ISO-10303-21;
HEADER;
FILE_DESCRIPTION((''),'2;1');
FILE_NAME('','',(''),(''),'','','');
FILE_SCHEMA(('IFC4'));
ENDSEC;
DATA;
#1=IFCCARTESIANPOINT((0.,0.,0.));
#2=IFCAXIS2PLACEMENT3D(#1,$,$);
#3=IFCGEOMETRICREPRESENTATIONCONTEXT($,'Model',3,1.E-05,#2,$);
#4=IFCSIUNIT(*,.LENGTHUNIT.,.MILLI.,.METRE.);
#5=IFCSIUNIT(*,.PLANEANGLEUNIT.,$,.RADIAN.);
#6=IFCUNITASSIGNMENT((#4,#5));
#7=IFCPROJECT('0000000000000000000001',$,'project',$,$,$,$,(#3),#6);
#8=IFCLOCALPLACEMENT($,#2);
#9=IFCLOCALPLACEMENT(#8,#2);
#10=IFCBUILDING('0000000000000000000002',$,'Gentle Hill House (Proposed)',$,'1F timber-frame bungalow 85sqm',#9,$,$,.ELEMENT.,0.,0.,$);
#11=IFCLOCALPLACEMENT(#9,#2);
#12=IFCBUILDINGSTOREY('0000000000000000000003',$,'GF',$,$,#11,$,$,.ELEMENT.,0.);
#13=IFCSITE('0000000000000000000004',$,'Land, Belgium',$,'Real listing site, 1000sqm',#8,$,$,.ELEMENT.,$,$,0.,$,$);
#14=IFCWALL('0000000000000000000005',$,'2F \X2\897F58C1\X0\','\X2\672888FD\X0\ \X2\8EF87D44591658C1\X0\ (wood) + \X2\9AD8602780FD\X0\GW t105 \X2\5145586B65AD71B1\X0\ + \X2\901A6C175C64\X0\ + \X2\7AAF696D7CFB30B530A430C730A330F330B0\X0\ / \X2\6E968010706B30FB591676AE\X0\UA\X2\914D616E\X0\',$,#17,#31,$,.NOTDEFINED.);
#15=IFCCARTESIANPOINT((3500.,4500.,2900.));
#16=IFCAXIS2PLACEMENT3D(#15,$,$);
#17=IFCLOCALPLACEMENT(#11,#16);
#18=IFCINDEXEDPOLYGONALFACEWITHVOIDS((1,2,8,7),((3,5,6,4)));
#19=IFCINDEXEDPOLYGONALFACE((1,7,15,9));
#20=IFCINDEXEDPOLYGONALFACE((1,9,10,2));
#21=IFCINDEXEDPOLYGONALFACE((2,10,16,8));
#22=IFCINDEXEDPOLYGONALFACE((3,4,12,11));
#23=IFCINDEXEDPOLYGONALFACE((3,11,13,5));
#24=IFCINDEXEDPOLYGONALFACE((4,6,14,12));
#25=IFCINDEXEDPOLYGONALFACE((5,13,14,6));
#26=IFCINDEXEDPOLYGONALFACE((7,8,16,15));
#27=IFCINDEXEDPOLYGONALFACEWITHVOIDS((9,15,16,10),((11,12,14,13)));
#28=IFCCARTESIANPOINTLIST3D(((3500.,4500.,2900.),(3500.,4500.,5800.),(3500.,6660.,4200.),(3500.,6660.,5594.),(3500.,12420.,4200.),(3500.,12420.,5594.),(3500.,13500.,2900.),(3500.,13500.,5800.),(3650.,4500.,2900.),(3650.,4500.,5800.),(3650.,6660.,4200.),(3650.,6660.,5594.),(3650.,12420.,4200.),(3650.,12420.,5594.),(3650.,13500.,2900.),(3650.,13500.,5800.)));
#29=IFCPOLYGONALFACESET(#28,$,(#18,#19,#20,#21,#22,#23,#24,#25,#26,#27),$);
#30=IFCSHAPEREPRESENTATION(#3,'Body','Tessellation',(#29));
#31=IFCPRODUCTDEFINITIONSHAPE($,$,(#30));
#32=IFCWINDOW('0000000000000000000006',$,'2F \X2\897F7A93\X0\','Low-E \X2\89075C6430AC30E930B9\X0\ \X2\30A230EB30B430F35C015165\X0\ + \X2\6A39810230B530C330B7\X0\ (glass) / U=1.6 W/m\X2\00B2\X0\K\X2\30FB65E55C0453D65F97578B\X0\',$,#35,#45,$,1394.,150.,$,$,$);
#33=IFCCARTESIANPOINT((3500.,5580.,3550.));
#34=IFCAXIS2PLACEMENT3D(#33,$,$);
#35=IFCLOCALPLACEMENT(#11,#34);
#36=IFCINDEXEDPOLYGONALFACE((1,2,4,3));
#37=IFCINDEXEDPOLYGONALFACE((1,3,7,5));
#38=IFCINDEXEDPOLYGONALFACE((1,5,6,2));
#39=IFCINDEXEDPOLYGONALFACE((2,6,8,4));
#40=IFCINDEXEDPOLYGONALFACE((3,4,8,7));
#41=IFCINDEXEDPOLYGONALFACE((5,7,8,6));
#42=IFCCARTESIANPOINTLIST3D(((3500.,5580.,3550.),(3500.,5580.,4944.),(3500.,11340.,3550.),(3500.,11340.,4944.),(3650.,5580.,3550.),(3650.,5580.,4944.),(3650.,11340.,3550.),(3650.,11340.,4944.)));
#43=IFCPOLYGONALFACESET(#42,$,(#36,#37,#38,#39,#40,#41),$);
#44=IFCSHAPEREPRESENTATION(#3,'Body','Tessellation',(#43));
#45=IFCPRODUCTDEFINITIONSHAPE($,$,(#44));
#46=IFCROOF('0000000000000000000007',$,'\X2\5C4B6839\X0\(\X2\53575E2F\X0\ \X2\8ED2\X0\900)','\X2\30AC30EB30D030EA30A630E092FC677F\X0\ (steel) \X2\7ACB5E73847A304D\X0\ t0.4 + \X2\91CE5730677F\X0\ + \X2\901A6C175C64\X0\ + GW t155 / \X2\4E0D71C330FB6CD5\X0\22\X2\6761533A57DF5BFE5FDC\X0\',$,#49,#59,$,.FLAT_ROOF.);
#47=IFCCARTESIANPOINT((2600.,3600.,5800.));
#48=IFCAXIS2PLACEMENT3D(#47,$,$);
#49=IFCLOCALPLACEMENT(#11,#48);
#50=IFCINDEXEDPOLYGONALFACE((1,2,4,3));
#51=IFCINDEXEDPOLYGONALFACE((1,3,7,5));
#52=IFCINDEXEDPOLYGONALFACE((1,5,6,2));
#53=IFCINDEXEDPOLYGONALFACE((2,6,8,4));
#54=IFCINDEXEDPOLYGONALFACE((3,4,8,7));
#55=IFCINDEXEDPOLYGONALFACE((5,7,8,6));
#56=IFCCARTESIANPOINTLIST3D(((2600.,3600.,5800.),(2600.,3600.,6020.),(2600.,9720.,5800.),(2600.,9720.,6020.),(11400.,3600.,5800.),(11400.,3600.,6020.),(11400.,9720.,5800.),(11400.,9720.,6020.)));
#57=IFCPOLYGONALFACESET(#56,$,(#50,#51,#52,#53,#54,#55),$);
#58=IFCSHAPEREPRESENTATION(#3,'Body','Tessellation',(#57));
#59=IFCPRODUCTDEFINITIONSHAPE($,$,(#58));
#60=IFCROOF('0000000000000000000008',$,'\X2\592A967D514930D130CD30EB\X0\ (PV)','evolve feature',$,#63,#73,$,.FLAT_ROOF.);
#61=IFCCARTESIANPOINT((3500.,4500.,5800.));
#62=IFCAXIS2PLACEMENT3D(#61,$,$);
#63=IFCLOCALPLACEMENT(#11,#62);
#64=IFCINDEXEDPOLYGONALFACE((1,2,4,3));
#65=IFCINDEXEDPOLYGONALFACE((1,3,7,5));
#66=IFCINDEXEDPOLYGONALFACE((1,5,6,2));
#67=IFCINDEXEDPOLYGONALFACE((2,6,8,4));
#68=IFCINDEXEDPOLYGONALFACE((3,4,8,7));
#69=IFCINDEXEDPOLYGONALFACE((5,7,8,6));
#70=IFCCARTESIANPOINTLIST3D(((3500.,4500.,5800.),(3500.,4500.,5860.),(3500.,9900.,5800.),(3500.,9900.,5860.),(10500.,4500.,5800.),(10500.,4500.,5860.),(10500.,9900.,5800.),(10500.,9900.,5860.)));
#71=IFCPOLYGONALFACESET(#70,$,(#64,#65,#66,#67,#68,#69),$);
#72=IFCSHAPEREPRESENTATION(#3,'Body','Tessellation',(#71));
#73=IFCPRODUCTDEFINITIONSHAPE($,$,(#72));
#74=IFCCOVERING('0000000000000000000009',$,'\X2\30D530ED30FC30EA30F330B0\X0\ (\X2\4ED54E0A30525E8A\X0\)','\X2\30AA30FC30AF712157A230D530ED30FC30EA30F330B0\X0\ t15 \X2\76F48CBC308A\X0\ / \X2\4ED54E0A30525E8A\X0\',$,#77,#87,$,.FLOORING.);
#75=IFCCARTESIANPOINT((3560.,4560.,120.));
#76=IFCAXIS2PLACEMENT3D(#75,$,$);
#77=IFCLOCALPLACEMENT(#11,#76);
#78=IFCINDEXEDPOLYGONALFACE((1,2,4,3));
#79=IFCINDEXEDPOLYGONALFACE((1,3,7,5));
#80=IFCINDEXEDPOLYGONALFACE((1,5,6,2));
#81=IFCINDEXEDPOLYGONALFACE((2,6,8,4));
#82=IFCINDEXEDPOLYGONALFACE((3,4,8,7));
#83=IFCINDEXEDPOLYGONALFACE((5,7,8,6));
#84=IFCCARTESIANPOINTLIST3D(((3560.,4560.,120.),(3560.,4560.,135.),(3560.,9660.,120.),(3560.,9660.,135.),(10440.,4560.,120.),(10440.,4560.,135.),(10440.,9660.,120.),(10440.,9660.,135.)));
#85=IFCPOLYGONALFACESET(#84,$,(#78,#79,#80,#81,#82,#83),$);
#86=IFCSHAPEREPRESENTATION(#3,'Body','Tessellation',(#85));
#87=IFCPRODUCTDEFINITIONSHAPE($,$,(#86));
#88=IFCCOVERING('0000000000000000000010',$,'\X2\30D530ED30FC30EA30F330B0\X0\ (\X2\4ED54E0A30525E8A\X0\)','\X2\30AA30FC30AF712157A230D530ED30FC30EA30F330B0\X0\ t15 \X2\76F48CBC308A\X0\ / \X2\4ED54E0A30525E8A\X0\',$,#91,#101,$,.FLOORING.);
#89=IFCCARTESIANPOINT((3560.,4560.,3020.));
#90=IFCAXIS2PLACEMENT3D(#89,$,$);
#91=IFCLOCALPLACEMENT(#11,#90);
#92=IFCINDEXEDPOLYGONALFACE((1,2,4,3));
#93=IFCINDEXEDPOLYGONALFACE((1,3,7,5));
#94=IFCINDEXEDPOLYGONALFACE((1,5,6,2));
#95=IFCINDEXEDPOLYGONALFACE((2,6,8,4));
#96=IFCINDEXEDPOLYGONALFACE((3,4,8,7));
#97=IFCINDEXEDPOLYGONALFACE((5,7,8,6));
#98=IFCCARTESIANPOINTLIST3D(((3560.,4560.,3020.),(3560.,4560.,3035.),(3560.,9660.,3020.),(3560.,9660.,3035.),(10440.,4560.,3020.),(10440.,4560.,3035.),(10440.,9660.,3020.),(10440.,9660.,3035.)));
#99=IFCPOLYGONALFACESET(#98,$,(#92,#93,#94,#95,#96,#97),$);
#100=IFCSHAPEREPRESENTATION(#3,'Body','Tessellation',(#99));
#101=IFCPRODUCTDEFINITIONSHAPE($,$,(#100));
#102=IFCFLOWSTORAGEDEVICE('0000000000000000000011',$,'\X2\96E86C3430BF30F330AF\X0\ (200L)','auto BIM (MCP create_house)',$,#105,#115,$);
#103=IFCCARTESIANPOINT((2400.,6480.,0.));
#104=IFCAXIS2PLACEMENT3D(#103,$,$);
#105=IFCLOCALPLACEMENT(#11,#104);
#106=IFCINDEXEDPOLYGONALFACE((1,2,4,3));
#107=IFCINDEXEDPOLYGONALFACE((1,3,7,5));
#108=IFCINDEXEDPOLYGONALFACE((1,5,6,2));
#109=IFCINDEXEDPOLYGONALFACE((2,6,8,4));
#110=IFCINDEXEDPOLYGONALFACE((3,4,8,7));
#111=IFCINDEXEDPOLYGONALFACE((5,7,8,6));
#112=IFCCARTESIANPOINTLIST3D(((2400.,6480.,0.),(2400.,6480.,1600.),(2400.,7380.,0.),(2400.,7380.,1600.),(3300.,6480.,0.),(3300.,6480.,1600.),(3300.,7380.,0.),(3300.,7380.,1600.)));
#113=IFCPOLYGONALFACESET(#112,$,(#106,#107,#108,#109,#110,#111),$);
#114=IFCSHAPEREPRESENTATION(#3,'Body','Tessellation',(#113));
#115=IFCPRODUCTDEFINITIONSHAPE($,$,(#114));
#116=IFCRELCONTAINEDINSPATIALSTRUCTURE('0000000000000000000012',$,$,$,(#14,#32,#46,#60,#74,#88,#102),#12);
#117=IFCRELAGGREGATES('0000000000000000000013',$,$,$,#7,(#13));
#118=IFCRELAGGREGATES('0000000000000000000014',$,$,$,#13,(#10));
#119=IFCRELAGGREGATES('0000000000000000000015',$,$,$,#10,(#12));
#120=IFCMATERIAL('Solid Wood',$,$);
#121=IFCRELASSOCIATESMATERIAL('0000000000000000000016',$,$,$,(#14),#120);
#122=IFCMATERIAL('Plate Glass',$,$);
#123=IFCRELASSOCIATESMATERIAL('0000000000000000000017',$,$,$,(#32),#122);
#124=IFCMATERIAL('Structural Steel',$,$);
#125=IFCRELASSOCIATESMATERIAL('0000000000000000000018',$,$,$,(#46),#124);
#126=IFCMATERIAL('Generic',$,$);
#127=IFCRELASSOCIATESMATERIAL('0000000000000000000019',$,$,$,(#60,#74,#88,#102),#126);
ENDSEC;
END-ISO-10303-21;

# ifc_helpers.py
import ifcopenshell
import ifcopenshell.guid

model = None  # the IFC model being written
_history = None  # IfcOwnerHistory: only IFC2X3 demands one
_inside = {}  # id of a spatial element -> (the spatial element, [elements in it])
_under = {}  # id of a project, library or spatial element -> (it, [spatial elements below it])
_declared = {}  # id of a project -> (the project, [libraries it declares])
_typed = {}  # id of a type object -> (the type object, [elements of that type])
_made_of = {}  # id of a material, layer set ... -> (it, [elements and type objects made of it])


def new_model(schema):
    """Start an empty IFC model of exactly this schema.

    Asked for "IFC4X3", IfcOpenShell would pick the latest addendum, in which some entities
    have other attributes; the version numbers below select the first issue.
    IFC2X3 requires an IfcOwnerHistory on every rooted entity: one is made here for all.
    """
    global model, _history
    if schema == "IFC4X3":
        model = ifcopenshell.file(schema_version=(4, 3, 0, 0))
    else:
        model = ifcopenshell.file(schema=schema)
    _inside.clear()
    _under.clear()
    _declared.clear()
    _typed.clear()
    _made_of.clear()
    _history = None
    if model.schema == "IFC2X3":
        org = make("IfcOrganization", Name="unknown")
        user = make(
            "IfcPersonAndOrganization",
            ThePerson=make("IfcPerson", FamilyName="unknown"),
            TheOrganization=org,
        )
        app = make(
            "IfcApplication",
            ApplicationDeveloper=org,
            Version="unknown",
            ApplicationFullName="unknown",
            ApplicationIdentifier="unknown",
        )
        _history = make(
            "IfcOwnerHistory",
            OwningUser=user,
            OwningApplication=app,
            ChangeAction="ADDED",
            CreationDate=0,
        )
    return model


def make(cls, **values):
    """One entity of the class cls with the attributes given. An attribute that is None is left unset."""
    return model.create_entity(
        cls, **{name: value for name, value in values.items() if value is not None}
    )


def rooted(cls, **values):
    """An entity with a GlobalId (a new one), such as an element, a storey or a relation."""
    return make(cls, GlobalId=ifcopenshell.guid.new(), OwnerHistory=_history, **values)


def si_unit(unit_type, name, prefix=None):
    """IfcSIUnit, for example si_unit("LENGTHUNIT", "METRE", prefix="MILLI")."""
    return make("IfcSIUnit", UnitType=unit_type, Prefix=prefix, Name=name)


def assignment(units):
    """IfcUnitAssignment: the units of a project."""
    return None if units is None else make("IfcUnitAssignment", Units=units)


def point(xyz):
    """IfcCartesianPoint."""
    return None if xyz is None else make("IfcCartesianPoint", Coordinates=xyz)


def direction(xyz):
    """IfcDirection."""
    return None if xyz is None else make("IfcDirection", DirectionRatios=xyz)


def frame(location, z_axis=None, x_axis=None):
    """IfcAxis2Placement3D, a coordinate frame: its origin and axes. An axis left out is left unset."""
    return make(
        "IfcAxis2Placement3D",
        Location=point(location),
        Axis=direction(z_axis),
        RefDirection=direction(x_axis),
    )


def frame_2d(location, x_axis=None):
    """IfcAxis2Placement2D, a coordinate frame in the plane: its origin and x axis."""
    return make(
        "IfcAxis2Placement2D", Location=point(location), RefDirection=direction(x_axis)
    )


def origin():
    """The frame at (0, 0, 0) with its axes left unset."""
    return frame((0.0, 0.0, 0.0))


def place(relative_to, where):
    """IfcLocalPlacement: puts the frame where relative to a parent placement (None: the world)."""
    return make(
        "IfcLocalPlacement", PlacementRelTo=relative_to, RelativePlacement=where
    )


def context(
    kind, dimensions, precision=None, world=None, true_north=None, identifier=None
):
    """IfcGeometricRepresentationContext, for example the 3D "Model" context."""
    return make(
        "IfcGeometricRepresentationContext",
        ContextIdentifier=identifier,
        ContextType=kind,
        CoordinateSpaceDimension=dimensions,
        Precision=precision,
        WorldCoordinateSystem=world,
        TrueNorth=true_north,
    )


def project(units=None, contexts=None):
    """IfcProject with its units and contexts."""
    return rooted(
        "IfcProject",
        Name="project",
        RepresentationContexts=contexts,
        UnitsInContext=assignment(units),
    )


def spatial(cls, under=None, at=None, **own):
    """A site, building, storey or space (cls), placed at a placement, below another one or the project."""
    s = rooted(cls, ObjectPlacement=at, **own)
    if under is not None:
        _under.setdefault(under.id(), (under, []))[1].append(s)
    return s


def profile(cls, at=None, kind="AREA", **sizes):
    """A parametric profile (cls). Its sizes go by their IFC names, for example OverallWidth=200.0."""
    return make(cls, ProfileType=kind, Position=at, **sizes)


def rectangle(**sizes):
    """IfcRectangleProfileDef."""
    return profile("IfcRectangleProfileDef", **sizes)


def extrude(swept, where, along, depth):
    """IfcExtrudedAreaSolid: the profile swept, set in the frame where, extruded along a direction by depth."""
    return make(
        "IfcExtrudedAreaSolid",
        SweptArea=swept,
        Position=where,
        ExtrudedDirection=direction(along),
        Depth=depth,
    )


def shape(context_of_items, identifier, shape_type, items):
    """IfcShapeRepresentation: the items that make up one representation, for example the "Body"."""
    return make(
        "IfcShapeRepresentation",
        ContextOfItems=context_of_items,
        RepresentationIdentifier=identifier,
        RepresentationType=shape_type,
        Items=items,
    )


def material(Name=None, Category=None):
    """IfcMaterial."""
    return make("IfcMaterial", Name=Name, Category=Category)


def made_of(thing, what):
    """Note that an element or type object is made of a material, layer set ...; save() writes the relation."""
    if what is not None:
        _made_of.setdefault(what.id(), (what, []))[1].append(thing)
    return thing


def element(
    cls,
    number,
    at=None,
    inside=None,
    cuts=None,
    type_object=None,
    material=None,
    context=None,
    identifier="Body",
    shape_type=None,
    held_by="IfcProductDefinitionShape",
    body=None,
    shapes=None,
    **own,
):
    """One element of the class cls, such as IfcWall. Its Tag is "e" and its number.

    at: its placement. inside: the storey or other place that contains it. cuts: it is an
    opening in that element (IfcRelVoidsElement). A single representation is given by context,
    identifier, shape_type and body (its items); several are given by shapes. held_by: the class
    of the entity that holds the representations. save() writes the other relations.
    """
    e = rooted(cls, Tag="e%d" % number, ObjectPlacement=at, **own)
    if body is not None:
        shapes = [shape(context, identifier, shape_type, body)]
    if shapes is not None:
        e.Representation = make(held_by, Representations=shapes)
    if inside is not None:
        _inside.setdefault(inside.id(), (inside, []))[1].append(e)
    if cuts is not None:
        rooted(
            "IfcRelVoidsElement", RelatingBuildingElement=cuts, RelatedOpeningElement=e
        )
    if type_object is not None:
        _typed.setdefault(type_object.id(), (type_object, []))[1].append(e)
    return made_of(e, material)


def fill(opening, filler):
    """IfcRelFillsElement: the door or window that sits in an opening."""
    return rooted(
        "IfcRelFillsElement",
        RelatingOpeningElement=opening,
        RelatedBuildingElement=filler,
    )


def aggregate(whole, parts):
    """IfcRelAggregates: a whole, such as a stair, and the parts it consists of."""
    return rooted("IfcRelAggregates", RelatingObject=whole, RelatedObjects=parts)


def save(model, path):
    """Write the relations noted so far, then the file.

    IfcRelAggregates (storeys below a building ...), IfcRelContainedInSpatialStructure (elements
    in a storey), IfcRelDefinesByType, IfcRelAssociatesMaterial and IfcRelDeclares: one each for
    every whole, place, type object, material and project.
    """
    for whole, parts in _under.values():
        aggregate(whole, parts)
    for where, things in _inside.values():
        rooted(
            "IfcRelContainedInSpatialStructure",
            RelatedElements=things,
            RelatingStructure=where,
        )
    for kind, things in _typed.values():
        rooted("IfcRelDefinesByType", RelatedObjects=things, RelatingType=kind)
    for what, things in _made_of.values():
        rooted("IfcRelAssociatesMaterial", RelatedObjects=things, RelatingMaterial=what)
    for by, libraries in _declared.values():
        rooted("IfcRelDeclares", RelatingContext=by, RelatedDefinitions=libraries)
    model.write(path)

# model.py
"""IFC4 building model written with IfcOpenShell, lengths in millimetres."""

from ifc_helpers import new_model, si_unit, frame, frame_2d, origin, place, context, project, spatial, rectangle, extrude, material, element, fill, save


model = new_model("IFC4")

# Units and contexts
model_context = context("Model", 3, precision=1e-05, world=origin())
ifc_project = project(units=[si_unit("LENGTHUNIT", "METRE", prefix="MILLI"), si_unit("PLANEANGLEUNIT", "RADIAN")], contexts=[model_context])

# Site, building, storey
site_placement = place(None, origin())
site = spatial("IfcSite", under=ifc_project, at=site_placement, Name="Land, Belgium", ObjectType="Real listing site, 1000sqm", CompositionType="ELEMENT", RefElevation=0.0)
building_placement = place(site_placement, origin())
building = spatial("IfcBuilding", under=site, at=building_placement, Name="Gentle Hill House (Proposed)", ObjectType="1F timber-frame bungalow 85sqm", CompositionType="ELEMENT", ElevationOfRefHeight=0.0, ElevationOfTerrain=0.0)
storey_placement = place(building_placement, origin())
storey = spatial("IfcBuildingStorey", under=building, at=storey_placement, Name="GF", CompositionType="ELEMENT", Elevation=0.0)

# Shared definitions
ifc_material_1 = material(Name="Solid Wood")
ifc_material_2 = material(Name="Generic")

# Shared definitions
ifc_material_3 = material(Name="Plate Glass")

# Wall, opening, window
wall_1_placement = place(storey_placement, frame((3500.0, 4500.0, 2900.0)))
wall_1 = element("IfcWall", 1, at=wall_1_placement, inside=storey, material=ifc_material_1, Name="2F 西壁", Description="木製 軸組外壁 (wood) + 高性能GW t105 充填断熱 + 通気層 + 窯業系サイディング / 準耐火・外皮UA配慮", PredefinedType="NOTDEFINED", context=model_context, shape_type="SweptSolid", body=[
    extrude(rectangle(XDim=150.0, YDim=9000.0, at=frame_2d((75.0, 4500.0))), frame((3500.0, 4500.0, 2900.0)), (0.0, 0.0, 1.0), 2900.0),
])
opening_1_placement = place(storey_placement, frame((3500.0, 5580.0, 3550.0)))
opening_1 = element("IfcOpeningElement", 2, at=opening_1_placement, cuts=wall_1, PredefinedType="NOTDEFINED", context=model_context, shape_type="SweptSolid", body=[
    extrude(rectangle(XDim=150.0, YDim=5760.0, at=frame_2d((75.0, 2880.0))), frame((3500.0, 5580.0, 3550.0)), (0.0, 0.0, 1.0), 1394.0),
])
window_1_placement = place(storey_placement, frame((3500.0, 5580.0, 3550.0)))
window_1 = element("IfcWindow", 3, at=window_1_placement, inside=storey, material=ifc_material_3, Name="2F 西窓", Description="Low-E 複層ガラス アルゴン封入 + 樹脂サッシ (glass) / U=1.6 W/m²K・日射取得型", OverallHeight=1394.0, OverallWidth=150.0, context=model_context, shape_type="SweptSolid", body=[
    extrude(rectangle(XDim=150.0, YDim=5760.0, at=frame_2d((75.0, 2880.0))), frame((3500.0, 5580.0, 3550.0)), (0.0, 0.0, 1.0), 1394.0),
])
fill(opening_1, window_1)

# Roofs
ifc_material_4 = material(Name="Structural Steel")
for number, where, name in (
    (4, (2600.0, 3600.0, 5800.0), "屋根(南帯 軒900)"),
):
    element("IfcRoof", number, at=place(storey_placement, frame(where)), inside=storey, material=ifc_material_4, Name=name, Description="ガルバリウム鋼板 (steel) 立平葺き t0.4 + 野地板 + 通気層 + GW t155 / 不燃・法22条区域対応", PredefinedType="FLAT_ROOF", context=model_context, shape_type="SweptSolid", body=[
        extrude(rectangle(XDim=8800.0, YDim=6120.0, at=frame_2d((4400.0, 3060.0))), frame((2600.0, 3600.0, 5800.0)), (0.0, 0.0, 1.0), 220.0),
    ])
roof_placement = place(storey_placement, frame((3500.0, 4500.0, 5800.0)))
element("IfcRoof", 5, at=roof_placement, inside=storey, material=ifc_material_2, Name="太陽光パネル (PV)", Description="evolve feature", PredefinedType="FLAT_ROOF", context=model_context, shape_type="SweptSolid", body=[
    extrude(rectangle(XDim=7000.0, YDim=5400.0, at=frame_2d((3500.0, 2700.0))), frame((3500.0, 4500.0, 5800.0)), (0.0, 0.0, 1.0), 60.0),
])

# Coverings
covering_1_placement = place(storey_placement, frame((3560.0, 4560.0, 120.0)))
element("IfcCovering", 6, at=covering_1_placement, inside=storey, material=ifc_material_2, Name="フローリング (仕上げ床)", Description="オーク無垢フローリング t15 直貼り / 仕上げ床", PredefinedType="FLOORING", context=model_context, shape_type="SweptSolid", body=[
    extrude(rectangle(XDim=6880.0, YDim=5100.0, at=frame_2d((3440.0, 2550.0))), frame((3560.0, 4560.0, 120.0)), (0.0, 0.0, 1.0), 15.0),
])
covering_2_placement = place(storey_placement, frame((3560.0, 4560.0, 3020.0)))
element("IfcCovering", 7, at=covering_2_placement, inside=storey, material=ifc_material_2, Name="フローリング (仕上げ床)", Description="オーク無垢フローリング t15 直貼り / 仕上げ床", PredefinedType="FLOORING", context=model_context, shape_type="SweptSolid", body=[
    extrude(rectangle(XDim=6880.0, YDim=5100.0, at=frame_2d((3440.0, 2550.0))), frame((3560.0, 4560.0, 3020.0)), (0.0, 0.0, 1.0), 15.0),
])

# Flow storage device
flow_storage_device_placement = place(storey_placement, frame((2400.0, 6480.0, 0.0)))
element("IfcFlowStorageDevice", 8, at=flow_storage_device_placement, inside=storey, material=ifc_material_2, Name="雨水タンク (200L)", Description="auto BIM (MCP create_house)", context=model_context, shape_type="SweptSolid", body=[
    extrude(rectangle(XDim=900.0, YDim=900.0, at=frame_2d((450.0, 450.0))), frame((2400.0, 6480.0, 0.0)), (0.0, 0.0, 1.0), 1600.0),
])

save(model, "model.ifc")
